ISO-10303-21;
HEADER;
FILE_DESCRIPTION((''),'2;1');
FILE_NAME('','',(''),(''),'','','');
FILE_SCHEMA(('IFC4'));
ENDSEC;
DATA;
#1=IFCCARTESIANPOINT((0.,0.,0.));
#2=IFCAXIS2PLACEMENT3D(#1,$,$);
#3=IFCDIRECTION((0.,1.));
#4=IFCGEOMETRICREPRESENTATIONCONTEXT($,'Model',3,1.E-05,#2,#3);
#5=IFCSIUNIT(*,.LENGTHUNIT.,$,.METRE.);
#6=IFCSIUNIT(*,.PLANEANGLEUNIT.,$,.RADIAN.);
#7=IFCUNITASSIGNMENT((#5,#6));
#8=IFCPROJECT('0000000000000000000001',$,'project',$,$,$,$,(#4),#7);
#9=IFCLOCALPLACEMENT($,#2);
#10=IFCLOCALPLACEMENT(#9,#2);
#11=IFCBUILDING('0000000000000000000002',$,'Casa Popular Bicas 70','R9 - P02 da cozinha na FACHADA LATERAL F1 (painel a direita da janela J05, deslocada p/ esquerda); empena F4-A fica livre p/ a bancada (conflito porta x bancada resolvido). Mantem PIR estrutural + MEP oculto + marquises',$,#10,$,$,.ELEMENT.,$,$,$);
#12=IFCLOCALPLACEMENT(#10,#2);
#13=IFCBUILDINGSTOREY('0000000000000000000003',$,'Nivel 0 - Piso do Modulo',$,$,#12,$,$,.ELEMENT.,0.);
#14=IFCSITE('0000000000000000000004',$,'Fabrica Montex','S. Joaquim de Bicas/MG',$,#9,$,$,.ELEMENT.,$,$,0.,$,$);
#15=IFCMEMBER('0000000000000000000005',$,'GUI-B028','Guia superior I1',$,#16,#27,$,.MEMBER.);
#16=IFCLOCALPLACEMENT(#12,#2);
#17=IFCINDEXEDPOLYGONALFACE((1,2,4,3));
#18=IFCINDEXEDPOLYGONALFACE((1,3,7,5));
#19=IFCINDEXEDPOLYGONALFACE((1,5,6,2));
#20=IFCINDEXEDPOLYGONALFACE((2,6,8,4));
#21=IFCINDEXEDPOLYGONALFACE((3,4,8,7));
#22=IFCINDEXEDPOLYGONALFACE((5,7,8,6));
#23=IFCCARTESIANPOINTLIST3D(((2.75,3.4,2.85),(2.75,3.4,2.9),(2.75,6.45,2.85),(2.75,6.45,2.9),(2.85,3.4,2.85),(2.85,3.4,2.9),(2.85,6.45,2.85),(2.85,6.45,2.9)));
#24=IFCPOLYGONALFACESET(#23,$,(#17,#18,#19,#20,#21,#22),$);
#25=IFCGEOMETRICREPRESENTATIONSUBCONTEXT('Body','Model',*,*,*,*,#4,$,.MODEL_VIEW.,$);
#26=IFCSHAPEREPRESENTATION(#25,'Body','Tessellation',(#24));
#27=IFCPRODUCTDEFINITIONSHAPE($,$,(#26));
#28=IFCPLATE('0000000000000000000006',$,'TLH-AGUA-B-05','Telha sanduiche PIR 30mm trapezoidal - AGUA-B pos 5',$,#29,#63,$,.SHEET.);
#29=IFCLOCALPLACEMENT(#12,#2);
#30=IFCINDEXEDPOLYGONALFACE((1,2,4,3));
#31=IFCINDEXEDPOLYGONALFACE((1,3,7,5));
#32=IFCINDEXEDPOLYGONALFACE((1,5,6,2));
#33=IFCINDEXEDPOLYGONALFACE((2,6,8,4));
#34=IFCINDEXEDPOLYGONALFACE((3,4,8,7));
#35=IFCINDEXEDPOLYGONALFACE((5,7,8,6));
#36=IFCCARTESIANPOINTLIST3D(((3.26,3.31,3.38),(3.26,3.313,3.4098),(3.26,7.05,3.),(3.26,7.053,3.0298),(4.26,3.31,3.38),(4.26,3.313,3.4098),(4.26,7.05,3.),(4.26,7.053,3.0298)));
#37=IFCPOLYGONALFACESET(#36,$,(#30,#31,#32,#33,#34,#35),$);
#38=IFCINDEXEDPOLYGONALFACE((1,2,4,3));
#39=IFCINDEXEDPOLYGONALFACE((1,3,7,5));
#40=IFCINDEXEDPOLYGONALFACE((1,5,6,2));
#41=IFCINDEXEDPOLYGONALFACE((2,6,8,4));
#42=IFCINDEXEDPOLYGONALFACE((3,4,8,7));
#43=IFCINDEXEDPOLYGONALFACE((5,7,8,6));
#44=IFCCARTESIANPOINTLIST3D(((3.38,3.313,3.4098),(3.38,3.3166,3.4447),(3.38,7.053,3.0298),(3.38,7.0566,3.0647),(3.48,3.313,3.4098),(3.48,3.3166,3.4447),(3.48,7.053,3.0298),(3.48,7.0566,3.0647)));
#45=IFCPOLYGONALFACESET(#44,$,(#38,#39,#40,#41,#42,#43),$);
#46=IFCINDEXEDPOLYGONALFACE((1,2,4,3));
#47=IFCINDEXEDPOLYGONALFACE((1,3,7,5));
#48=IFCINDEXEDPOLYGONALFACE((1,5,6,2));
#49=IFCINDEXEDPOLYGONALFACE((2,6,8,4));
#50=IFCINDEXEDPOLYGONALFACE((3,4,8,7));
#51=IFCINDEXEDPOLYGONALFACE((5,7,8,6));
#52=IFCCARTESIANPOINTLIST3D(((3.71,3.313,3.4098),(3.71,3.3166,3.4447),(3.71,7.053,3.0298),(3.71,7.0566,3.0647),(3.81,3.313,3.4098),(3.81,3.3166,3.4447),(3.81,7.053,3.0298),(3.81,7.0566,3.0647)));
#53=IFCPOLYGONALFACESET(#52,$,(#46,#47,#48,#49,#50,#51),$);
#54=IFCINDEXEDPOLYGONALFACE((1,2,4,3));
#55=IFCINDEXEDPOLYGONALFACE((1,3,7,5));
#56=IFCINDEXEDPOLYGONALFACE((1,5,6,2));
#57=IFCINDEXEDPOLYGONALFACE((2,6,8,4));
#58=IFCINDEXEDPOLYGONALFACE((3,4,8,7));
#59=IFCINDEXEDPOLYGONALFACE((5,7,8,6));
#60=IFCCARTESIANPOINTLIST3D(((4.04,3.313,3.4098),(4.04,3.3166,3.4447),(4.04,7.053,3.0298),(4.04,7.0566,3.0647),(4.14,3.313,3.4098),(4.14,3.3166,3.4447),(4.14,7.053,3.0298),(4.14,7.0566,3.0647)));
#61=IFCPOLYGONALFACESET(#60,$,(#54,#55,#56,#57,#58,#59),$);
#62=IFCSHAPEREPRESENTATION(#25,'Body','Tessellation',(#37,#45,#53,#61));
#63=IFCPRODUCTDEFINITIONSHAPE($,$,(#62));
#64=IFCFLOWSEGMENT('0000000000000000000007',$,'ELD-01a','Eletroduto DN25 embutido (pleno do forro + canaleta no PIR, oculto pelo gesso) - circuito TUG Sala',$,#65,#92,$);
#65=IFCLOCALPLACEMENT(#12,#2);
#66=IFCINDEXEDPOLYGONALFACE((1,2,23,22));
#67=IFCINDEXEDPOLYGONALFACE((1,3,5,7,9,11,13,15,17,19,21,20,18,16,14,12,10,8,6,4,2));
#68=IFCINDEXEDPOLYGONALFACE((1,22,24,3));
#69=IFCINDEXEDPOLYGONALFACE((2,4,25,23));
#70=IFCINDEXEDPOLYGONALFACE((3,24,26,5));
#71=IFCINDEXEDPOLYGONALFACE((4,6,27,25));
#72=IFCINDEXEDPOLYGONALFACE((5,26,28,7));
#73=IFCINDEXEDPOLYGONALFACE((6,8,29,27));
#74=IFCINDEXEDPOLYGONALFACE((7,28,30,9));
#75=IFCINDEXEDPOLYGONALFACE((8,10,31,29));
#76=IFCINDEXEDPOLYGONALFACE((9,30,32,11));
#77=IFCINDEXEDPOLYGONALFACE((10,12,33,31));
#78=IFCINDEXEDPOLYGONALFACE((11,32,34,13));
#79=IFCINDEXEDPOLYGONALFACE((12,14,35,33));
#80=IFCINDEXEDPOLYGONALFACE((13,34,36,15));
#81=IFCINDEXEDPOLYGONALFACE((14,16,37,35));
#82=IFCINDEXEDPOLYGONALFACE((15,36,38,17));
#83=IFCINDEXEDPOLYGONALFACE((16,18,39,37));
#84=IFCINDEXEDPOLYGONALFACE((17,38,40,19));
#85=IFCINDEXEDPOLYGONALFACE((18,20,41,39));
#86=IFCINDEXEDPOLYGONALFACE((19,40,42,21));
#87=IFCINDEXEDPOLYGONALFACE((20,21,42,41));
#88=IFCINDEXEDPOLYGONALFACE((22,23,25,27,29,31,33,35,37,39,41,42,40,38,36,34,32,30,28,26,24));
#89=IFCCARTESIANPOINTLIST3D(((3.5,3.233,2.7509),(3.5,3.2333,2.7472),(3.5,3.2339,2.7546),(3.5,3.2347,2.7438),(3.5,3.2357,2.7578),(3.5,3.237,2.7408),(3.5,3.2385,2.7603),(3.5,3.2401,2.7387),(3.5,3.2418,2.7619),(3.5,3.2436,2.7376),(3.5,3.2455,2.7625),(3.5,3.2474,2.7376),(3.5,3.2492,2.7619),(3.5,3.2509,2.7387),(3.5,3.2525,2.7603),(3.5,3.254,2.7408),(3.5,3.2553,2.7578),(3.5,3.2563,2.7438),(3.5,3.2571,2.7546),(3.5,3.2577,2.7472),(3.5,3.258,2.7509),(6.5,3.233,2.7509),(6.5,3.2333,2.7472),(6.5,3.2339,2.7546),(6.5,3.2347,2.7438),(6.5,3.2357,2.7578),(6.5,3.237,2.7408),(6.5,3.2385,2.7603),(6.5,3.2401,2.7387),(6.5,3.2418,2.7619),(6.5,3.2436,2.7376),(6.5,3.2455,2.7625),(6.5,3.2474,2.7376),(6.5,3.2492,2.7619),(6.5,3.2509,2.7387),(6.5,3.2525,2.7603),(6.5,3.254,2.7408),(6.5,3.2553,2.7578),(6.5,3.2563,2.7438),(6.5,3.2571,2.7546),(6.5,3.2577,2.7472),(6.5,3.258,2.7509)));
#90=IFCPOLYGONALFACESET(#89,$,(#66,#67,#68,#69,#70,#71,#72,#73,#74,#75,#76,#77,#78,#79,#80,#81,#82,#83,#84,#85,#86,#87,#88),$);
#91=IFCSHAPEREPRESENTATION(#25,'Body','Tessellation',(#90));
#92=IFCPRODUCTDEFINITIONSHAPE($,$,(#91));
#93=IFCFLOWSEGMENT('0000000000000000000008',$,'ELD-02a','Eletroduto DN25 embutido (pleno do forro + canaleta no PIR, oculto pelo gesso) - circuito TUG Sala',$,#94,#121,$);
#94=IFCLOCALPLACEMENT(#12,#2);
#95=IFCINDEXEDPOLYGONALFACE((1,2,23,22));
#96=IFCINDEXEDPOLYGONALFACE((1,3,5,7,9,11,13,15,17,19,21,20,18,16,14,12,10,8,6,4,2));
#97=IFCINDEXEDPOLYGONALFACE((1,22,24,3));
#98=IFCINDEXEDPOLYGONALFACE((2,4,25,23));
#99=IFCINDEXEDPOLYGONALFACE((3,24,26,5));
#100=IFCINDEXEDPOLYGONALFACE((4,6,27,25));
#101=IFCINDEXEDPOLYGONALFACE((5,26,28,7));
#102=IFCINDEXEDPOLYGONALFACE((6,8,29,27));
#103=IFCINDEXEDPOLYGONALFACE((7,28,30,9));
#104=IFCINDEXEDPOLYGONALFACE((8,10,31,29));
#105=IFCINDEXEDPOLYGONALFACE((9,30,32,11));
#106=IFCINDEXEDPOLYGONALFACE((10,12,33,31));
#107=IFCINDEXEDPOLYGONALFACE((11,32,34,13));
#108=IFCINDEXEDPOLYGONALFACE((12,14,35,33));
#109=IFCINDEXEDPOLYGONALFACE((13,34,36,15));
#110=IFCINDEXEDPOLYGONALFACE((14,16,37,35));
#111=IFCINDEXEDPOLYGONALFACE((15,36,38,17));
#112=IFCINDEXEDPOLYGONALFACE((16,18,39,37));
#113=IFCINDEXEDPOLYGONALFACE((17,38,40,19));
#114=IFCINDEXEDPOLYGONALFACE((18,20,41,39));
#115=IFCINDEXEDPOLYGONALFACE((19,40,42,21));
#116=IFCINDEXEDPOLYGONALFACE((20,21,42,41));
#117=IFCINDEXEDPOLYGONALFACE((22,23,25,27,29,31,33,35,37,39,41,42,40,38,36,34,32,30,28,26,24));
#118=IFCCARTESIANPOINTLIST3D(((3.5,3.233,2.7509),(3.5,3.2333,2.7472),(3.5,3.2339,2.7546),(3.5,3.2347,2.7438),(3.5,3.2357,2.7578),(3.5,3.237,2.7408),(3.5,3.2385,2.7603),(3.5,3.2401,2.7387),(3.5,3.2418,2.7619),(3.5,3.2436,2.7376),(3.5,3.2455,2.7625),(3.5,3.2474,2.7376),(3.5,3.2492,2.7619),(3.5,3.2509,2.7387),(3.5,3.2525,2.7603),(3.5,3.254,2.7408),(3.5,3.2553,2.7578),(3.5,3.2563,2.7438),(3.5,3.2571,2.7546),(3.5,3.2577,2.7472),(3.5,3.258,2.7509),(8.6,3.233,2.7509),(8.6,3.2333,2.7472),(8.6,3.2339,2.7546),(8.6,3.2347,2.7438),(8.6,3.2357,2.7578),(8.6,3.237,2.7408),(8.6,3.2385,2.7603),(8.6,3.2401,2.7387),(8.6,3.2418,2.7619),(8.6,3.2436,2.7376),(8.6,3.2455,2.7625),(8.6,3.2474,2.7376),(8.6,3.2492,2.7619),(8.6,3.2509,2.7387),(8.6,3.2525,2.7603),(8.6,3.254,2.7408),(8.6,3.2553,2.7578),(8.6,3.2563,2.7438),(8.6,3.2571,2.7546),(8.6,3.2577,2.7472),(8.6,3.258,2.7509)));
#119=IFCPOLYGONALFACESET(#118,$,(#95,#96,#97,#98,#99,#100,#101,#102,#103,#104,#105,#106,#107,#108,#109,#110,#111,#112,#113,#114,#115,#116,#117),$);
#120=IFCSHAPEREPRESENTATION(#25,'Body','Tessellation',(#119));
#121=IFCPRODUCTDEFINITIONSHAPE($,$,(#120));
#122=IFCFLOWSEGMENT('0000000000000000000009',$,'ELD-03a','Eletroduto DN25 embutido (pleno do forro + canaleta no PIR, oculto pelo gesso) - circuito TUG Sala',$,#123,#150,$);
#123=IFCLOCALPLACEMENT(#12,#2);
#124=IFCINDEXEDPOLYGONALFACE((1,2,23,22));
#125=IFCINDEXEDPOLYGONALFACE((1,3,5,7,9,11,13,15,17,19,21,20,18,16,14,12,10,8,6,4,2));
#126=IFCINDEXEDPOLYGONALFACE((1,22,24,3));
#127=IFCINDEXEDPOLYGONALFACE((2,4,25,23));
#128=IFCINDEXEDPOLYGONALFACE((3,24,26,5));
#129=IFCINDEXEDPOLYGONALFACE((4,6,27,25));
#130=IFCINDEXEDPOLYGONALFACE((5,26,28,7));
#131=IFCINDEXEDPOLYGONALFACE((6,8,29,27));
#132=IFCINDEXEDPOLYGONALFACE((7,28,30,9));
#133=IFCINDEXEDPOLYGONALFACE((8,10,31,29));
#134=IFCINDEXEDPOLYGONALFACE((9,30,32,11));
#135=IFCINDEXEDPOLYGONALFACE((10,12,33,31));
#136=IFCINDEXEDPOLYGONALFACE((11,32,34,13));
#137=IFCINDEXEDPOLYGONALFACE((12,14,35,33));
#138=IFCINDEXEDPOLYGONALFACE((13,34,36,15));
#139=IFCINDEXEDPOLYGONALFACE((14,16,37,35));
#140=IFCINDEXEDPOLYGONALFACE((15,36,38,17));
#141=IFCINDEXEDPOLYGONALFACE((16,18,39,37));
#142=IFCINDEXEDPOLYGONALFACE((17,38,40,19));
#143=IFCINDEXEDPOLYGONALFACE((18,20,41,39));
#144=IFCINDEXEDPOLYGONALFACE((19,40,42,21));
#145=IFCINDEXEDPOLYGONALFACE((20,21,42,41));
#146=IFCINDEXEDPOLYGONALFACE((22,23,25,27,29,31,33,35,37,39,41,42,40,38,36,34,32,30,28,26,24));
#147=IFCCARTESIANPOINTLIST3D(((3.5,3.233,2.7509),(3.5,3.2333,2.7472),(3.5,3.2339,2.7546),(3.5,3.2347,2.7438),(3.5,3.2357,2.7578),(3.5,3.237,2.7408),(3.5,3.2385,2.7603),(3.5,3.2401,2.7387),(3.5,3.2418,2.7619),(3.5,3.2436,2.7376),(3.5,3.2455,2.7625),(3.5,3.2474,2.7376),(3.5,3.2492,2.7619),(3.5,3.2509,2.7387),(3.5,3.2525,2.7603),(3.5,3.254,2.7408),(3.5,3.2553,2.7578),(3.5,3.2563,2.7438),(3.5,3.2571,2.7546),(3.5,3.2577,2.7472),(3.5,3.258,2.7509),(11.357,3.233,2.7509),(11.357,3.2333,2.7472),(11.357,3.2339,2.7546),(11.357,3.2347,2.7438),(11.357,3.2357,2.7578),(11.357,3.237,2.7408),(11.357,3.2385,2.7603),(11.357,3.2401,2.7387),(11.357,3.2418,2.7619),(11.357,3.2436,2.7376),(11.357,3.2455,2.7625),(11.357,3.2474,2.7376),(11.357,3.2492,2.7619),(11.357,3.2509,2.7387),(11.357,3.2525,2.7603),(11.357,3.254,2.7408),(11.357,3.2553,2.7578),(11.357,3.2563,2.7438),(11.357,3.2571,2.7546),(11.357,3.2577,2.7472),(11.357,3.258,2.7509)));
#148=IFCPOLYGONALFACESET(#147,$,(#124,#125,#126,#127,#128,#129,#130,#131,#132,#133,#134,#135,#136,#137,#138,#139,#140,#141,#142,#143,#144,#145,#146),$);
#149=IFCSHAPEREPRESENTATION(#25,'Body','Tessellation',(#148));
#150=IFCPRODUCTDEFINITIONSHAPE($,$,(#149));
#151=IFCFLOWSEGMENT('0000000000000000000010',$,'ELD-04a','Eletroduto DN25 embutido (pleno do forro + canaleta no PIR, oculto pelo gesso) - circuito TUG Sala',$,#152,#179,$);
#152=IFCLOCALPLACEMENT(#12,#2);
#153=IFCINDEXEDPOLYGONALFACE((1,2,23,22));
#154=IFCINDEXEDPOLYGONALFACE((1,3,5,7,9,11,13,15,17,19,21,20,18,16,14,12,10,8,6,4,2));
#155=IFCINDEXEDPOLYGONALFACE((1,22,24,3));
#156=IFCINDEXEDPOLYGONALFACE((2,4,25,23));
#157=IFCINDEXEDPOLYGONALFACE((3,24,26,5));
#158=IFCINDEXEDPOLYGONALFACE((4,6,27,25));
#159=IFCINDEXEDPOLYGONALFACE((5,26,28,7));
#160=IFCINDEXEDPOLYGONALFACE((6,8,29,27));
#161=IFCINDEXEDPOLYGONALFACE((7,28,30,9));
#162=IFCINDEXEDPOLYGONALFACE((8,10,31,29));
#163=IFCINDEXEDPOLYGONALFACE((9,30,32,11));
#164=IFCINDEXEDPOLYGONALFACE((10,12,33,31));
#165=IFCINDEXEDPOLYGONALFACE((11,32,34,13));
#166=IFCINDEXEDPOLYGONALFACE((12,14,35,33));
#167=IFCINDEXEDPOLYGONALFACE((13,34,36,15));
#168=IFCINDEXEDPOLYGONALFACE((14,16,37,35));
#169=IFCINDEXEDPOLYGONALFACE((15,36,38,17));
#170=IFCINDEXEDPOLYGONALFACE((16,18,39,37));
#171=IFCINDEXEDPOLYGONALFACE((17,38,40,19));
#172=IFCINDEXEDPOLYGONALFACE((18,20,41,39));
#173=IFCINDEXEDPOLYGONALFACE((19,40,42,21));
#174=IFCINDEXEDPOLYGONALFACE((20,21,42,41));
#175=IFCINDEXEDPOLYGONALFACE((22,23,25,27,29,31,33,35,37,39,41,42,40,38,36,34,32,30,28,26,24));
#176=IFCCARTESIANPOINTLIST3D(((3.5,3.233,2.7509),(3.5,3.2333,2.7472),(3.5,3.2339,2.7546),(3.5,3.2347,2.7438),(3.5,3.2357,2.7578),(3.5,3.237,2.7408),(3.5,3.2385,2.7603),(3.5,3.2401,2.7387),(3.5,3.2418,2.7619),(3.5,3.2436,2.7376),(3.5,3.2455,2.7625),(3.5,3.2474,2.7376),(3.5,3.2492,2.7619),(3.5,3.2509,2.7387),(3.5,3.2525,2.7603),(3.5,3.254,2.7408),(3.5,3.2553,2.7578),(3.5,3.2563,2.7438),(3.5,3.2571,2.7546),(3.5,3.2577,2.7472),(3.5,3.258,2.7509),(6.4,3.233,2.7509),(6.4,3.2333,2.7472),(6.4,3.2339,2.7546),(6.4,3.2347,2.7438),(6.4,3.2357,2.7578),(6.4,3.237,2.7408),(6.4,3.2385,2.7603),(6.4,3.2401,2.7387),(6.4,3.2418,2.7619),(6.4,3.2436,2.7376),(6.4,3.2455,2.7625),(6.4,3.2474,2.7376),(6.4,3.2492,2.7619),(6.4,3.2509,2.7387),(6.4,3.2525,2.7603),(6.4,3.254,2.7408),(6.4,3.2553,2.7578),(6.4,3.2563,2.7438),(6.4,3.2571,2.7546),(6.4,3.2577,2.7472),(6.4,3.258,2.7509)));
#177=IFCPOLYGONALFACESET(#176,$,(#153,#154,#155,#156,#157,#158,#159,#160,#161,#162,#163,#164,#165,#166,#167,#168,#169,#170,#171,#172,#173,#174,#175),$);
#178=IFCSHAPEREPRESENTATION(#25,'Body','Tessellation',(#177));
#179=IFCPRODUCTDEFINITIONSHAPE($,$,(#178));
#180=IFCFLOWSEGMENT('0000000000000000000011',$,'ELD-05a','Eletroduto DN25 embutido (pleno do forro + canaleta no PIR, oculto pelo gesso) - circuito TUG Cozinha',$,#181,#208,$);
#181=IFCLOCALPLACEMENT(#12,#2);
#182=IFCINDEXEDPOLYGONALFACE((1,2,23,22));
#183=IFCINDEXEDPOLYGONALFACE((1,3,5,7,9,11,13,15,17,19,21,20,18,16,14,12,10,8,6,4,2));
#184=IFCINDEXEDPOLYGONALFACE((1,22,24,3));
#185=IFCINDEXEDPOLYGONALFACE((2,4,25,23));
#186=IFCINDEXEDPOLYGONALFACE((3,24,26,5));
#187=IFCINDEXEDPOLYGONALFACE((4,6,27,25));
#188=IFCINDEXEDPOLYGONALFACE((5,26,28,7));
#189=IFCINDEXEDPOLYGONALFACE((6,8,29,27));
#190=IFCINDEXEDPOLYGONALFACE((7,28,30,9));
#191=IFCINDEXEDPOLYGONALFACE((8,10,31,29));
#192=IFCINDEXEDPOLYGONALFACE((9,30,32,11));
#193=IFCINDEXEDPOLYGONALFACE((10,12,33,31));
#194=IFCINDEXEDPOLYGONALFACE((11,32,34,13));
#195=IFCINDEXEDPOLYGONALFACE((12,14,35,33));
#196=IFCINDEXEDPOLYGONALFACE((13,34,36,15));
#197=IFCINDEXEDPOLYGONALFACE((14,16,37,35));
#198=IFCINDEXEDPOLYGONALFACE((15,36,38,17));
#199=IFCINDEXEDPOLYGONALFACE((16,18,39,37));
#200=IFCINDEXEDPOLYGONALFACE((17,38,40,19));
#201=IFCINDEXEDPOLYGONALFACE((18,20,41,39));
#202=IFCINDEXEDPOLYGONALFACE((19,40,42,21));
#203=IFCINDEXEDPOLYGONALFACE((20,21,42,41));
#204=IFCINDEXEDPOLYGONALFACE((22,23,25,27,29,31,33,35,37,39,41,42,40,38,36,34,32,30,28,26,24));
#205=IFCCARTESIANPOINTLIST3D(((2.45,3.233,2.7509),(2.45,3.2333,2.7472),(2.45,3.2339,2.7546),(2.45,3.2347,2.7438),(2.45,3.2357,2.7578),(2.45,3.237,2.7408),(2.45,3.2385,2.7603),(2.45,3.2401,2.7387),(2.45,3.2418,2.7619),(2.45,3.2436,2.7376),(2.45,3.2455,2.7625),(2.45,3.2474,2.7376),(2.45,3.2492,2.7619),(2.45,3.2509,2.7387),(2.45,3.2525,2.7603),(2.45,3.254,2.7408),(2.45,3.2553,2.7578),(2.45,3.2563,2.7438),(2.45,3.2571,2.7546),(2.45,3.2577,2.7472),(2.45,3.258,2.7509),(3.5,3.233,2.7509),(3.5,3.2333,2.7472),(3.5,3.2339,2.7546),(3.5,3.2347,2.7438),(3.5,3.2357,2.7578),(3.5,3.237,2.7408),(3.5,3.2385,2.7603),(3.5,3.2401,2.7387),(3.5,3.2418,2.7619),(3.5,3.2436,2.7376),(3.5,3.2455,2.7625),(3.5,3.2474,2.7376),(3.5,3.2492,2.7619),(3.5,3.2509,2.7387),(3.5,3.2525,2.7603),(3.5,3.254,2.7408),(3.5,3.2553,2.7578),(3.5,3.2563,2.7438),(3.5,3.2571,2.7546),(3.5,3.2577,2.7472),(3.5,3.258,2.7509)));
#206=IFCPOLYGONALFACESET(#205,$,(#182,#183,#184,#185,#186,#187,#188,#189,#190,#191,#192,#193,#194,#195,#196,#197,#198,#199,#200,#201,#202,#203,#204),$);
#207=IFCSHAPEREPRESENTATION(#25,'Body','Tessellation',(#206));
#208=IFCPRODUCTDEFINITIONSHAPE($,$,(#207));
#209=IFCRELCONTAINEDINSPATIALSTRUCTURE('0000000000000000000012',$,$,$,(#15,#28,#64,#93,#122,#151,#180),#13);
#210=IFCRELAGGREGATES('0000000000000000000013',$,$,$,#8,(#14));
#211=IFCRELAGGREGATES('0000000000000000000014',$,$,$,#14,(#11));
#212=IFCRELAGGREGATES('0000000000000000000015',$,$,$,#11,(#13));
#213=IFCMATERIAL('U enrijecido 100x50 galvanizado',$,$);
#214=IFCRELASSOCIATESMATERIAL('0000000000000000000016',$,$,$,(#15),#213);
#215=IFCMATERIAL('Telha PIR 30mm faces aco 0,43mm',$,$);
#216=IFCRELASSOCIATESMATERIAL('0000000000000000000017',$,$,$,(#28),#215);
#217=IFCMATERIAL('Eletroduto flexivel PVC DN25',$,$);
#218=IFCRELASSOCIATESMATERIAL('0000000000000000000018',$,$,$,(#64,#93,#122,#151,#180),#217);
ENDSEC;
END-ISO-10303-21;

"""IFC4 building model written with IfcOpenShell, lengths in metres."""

from ifc_helpers import new_model, si_unit, direction, frame, frame_2d, origin, origin_2d, place, context, subcontext, project, spatial, rectangle, circle, extrude, material, element, save


model = new_model("IFC4")

# Units and contexts
model_context = context("Model", 3, precision=1e-05, world=origin(), true_north=direction((0.0, 1.0)))
body_context = subcontext(model_context, "Body", "Model", "MODEL_VIEW")
ifc_project = project(units=[si_unit("LENGTHUNIT", "METRE"), si_unit("PLANEANGLEUNIT", "RADIAN")], contexts=[model_context])

# Site, building, storey
site_placement = place(None, origin())
site = spatial("IfcSite", under=ifc_project, at=site_placement, Name="Fabrica Montex", Description="S. Joaquim de Bicas/MG", CompositionType="ELEMENT", RefElevation=0.0)
building_placement = place(site_placement, origin())
building = spatial("IfcBuilding", under=site, at=building_placement, Name="Casa Popular Bicas 70", Description="R9 - P02 da cozinha na FACHADA LATERAL F1 (painel a direita da janela J05, deslocada p/ esquerda); empena F4-A fica livre p/ a bancada (conflito porta x bancada resolvido). Mantem PIR estrutural + MEP oculto + marquises", CompositionType="ELEMENT")
storey_placement = place(building_placement, origin())
storey = spatial("IfcBuildingStorey", under=building, at=storey_placement, Name="Nivel 0 - Piso do Modulo", CompositionType="ELEMENT", Elevation=0.0)

# Member
ifc_material_1 = material(Name="U enrijecido 100x50 galvanizado")
member_placement = place(storey_placement, frame((2.8, 3.4, 2.875), z_axis=(0.0, 1.0, 0.0), x_axis=(0.0, 0.0, 1.0)))
element("IfcMember", 1, at=member_placement, inside=storey, material=ifc_material_1, Name="GUI-B028", Description="Guia superior I1", PredefinedType="MEMBER", context=body_context, shape_type="SweptSolid", body=[
    extrude(rectangle(XDim=0.05, YDim=0.1, at=origin_2d()), origin(), (0.0, 0.0, 1.0), 3.05),
])

# Plate
ifc_material_2 = material(Name="Telha PIR 30mm faces aco 0,43mm")
plate_placement = place(storey_placement, frame((3.26, 3.31, 3.38), z_axis=(0.0, 0.101084, 0.994878), x_axis=(1.0, 0.0, 0.0)))
element("IfcPlate", 2, at=plate_placement, inside=storey, material=ifc_material_2, Name="TLH-AGUA-B-05", Description="Telha sanduiche PIR 30mm trapezoidal - AGUA-B pos 5", PredefinedType="SHEET", context=body_context, shape_type="SweptSolid", body=[
    extrude(rectangle(XDim=1.0, YDim=3.7593, at=frame_2d((0.5, 1.8796))), origin(), (0.0, 0.0, 1.0), 0.03),
    extrude(rectangle(XDim=0.1, YDim=3.7593, at=frame_2d((0.17, 1.8796))), frame((0.0, 0.0, 0.03)), (0.0, 0.0, 1.0), 0.035),
    extrude(rectangle(XDim=0.1, YDim=3.7593, at=frame_2d((0.5, 1.8796))), frame((0.0, 0.0, 0.03)), (0.0, 0.0, 1.0), 0.035),
    extrude(rectangle(XDim=0.1, YDim=3.7593, at=frame_2d((0.83, 1.8796))), frame((0.0, 0.0, 0.03)), (0.0, 0.0, 1.0), 0.035),
])

# Flow segments
ifc_material_3 = material(Name="Eletroduto flexivel PVC DN25")
flow_segment_1_placement = place(storey_placement, frame((3.5, 3.2455, 2.75), z_axis=(1.0, 0.0, 0.0), x_axis=(0.0, 0.0, 1.0)))
element("IfcFlowSegment", 3, at=flow_segment_1_placement, inside=storey, material=ifc_material_3, Name="ELD-01a", Description="Eletroduto DN25 embutido (pleno do forro + canaleta no PIR, oculto pelo gesso) - circuito TUG Sala", context=body_context, shape_type="SweptSolid", body=[
    extrude(circle(Radius=0.0125, at=origin_2d()), origin(), (0.0, 0.0, 1.0), 3.0),
])
flow_segment_2_placement = place(storey_placement, frame((3.5, 3.2455, 2.75), z_axis=(1.0, 0.0, 0.0), x_axis=(0.0, 0.0, 1.0)))
element("IfcFlowSegment", 4, at=flow_segment_2_placement, inside=storey, material=ifc_material_3, Name="ELD-02a", Description="Eletroduto DN25 embutido (pleno do forro + canaleta no PIR, oculto pelo gesso) - circuito TUG Sala", context=body_context, shape_type="SweptSolid", body=[
    extrude(circle(Radius=0.0125, at=origin_2d()), origin(), (0.0, 0.0, 1.0), 5.1),
])
flow_segment_3_placement = place(storey_placement, frame((3.5, 3.2455, 2.75), z_axis=(1.0, 0.0, 0.0), x_axis=(0.0, 0.0, 1.0)))
element("IfcFlowSegment", 5, at=flow_segment_3_placement, inside=storey, material=ifc_material_3, Name="ELD-03a", Description="Eletroduto DN25 embutido (pleno do forro + canaleta no PIR, oculto pelo gesso) - circuito TUG Sala", context=body_context, shape_type="SweptSolid", body=[
    extrude(circle(Radius=0.0125, at=origin_2d()), origin(), (0.0, 0.0, 1.0), 7.857),
])
flow_segment_4_placement = place(storey_placement, frame((3.5, 3.2455, 2.75), z_axis=(1.0, 0.0, 0.0), x_axis=(0.0, 0.0, 1.0)))
element("IfcFlowSegment", 6, at=flow_segment_4_placement, inside=storey, material=ifc_material_3, Name="ELD-04a", Description="Eletroduto DN25 embutido (pleno do forro + canaleta no PIR, oculto pelo gesso) - circuito TUG Sala", context=body_context, shape_type="SweptSolid", body=[
    extrude(circle(Radius=0.0125, at=origin_2d()), origin(), (0.0, 0.0, 1.0), 2.9),
])
flow_segment_5_placement = place(storey_placement, frame((3.5, 3.2455, 2.75), z_axis=(-1.0, 0.0, 0.0), x_axis=(0.0, 0.0, 1.0)))
element("IfcFlowSegment", 7, at=flow_segment_5_placement, inside=storey, material=ifc_material_3, Name="ELD-05a", Description="Eletroduto DN25 embutido (pleno do forro + canaleta no PIR, oculto pelo gesso) - circuito TUG Cozinha", context=body_context, shape_type="SweptSolid", body=[
    extrude(circle(Radius=0.0125, at=origin_2d()), origin(), (0.0, 0.0, 1.0), 1.05),
])

save(model, "model.ifc")
